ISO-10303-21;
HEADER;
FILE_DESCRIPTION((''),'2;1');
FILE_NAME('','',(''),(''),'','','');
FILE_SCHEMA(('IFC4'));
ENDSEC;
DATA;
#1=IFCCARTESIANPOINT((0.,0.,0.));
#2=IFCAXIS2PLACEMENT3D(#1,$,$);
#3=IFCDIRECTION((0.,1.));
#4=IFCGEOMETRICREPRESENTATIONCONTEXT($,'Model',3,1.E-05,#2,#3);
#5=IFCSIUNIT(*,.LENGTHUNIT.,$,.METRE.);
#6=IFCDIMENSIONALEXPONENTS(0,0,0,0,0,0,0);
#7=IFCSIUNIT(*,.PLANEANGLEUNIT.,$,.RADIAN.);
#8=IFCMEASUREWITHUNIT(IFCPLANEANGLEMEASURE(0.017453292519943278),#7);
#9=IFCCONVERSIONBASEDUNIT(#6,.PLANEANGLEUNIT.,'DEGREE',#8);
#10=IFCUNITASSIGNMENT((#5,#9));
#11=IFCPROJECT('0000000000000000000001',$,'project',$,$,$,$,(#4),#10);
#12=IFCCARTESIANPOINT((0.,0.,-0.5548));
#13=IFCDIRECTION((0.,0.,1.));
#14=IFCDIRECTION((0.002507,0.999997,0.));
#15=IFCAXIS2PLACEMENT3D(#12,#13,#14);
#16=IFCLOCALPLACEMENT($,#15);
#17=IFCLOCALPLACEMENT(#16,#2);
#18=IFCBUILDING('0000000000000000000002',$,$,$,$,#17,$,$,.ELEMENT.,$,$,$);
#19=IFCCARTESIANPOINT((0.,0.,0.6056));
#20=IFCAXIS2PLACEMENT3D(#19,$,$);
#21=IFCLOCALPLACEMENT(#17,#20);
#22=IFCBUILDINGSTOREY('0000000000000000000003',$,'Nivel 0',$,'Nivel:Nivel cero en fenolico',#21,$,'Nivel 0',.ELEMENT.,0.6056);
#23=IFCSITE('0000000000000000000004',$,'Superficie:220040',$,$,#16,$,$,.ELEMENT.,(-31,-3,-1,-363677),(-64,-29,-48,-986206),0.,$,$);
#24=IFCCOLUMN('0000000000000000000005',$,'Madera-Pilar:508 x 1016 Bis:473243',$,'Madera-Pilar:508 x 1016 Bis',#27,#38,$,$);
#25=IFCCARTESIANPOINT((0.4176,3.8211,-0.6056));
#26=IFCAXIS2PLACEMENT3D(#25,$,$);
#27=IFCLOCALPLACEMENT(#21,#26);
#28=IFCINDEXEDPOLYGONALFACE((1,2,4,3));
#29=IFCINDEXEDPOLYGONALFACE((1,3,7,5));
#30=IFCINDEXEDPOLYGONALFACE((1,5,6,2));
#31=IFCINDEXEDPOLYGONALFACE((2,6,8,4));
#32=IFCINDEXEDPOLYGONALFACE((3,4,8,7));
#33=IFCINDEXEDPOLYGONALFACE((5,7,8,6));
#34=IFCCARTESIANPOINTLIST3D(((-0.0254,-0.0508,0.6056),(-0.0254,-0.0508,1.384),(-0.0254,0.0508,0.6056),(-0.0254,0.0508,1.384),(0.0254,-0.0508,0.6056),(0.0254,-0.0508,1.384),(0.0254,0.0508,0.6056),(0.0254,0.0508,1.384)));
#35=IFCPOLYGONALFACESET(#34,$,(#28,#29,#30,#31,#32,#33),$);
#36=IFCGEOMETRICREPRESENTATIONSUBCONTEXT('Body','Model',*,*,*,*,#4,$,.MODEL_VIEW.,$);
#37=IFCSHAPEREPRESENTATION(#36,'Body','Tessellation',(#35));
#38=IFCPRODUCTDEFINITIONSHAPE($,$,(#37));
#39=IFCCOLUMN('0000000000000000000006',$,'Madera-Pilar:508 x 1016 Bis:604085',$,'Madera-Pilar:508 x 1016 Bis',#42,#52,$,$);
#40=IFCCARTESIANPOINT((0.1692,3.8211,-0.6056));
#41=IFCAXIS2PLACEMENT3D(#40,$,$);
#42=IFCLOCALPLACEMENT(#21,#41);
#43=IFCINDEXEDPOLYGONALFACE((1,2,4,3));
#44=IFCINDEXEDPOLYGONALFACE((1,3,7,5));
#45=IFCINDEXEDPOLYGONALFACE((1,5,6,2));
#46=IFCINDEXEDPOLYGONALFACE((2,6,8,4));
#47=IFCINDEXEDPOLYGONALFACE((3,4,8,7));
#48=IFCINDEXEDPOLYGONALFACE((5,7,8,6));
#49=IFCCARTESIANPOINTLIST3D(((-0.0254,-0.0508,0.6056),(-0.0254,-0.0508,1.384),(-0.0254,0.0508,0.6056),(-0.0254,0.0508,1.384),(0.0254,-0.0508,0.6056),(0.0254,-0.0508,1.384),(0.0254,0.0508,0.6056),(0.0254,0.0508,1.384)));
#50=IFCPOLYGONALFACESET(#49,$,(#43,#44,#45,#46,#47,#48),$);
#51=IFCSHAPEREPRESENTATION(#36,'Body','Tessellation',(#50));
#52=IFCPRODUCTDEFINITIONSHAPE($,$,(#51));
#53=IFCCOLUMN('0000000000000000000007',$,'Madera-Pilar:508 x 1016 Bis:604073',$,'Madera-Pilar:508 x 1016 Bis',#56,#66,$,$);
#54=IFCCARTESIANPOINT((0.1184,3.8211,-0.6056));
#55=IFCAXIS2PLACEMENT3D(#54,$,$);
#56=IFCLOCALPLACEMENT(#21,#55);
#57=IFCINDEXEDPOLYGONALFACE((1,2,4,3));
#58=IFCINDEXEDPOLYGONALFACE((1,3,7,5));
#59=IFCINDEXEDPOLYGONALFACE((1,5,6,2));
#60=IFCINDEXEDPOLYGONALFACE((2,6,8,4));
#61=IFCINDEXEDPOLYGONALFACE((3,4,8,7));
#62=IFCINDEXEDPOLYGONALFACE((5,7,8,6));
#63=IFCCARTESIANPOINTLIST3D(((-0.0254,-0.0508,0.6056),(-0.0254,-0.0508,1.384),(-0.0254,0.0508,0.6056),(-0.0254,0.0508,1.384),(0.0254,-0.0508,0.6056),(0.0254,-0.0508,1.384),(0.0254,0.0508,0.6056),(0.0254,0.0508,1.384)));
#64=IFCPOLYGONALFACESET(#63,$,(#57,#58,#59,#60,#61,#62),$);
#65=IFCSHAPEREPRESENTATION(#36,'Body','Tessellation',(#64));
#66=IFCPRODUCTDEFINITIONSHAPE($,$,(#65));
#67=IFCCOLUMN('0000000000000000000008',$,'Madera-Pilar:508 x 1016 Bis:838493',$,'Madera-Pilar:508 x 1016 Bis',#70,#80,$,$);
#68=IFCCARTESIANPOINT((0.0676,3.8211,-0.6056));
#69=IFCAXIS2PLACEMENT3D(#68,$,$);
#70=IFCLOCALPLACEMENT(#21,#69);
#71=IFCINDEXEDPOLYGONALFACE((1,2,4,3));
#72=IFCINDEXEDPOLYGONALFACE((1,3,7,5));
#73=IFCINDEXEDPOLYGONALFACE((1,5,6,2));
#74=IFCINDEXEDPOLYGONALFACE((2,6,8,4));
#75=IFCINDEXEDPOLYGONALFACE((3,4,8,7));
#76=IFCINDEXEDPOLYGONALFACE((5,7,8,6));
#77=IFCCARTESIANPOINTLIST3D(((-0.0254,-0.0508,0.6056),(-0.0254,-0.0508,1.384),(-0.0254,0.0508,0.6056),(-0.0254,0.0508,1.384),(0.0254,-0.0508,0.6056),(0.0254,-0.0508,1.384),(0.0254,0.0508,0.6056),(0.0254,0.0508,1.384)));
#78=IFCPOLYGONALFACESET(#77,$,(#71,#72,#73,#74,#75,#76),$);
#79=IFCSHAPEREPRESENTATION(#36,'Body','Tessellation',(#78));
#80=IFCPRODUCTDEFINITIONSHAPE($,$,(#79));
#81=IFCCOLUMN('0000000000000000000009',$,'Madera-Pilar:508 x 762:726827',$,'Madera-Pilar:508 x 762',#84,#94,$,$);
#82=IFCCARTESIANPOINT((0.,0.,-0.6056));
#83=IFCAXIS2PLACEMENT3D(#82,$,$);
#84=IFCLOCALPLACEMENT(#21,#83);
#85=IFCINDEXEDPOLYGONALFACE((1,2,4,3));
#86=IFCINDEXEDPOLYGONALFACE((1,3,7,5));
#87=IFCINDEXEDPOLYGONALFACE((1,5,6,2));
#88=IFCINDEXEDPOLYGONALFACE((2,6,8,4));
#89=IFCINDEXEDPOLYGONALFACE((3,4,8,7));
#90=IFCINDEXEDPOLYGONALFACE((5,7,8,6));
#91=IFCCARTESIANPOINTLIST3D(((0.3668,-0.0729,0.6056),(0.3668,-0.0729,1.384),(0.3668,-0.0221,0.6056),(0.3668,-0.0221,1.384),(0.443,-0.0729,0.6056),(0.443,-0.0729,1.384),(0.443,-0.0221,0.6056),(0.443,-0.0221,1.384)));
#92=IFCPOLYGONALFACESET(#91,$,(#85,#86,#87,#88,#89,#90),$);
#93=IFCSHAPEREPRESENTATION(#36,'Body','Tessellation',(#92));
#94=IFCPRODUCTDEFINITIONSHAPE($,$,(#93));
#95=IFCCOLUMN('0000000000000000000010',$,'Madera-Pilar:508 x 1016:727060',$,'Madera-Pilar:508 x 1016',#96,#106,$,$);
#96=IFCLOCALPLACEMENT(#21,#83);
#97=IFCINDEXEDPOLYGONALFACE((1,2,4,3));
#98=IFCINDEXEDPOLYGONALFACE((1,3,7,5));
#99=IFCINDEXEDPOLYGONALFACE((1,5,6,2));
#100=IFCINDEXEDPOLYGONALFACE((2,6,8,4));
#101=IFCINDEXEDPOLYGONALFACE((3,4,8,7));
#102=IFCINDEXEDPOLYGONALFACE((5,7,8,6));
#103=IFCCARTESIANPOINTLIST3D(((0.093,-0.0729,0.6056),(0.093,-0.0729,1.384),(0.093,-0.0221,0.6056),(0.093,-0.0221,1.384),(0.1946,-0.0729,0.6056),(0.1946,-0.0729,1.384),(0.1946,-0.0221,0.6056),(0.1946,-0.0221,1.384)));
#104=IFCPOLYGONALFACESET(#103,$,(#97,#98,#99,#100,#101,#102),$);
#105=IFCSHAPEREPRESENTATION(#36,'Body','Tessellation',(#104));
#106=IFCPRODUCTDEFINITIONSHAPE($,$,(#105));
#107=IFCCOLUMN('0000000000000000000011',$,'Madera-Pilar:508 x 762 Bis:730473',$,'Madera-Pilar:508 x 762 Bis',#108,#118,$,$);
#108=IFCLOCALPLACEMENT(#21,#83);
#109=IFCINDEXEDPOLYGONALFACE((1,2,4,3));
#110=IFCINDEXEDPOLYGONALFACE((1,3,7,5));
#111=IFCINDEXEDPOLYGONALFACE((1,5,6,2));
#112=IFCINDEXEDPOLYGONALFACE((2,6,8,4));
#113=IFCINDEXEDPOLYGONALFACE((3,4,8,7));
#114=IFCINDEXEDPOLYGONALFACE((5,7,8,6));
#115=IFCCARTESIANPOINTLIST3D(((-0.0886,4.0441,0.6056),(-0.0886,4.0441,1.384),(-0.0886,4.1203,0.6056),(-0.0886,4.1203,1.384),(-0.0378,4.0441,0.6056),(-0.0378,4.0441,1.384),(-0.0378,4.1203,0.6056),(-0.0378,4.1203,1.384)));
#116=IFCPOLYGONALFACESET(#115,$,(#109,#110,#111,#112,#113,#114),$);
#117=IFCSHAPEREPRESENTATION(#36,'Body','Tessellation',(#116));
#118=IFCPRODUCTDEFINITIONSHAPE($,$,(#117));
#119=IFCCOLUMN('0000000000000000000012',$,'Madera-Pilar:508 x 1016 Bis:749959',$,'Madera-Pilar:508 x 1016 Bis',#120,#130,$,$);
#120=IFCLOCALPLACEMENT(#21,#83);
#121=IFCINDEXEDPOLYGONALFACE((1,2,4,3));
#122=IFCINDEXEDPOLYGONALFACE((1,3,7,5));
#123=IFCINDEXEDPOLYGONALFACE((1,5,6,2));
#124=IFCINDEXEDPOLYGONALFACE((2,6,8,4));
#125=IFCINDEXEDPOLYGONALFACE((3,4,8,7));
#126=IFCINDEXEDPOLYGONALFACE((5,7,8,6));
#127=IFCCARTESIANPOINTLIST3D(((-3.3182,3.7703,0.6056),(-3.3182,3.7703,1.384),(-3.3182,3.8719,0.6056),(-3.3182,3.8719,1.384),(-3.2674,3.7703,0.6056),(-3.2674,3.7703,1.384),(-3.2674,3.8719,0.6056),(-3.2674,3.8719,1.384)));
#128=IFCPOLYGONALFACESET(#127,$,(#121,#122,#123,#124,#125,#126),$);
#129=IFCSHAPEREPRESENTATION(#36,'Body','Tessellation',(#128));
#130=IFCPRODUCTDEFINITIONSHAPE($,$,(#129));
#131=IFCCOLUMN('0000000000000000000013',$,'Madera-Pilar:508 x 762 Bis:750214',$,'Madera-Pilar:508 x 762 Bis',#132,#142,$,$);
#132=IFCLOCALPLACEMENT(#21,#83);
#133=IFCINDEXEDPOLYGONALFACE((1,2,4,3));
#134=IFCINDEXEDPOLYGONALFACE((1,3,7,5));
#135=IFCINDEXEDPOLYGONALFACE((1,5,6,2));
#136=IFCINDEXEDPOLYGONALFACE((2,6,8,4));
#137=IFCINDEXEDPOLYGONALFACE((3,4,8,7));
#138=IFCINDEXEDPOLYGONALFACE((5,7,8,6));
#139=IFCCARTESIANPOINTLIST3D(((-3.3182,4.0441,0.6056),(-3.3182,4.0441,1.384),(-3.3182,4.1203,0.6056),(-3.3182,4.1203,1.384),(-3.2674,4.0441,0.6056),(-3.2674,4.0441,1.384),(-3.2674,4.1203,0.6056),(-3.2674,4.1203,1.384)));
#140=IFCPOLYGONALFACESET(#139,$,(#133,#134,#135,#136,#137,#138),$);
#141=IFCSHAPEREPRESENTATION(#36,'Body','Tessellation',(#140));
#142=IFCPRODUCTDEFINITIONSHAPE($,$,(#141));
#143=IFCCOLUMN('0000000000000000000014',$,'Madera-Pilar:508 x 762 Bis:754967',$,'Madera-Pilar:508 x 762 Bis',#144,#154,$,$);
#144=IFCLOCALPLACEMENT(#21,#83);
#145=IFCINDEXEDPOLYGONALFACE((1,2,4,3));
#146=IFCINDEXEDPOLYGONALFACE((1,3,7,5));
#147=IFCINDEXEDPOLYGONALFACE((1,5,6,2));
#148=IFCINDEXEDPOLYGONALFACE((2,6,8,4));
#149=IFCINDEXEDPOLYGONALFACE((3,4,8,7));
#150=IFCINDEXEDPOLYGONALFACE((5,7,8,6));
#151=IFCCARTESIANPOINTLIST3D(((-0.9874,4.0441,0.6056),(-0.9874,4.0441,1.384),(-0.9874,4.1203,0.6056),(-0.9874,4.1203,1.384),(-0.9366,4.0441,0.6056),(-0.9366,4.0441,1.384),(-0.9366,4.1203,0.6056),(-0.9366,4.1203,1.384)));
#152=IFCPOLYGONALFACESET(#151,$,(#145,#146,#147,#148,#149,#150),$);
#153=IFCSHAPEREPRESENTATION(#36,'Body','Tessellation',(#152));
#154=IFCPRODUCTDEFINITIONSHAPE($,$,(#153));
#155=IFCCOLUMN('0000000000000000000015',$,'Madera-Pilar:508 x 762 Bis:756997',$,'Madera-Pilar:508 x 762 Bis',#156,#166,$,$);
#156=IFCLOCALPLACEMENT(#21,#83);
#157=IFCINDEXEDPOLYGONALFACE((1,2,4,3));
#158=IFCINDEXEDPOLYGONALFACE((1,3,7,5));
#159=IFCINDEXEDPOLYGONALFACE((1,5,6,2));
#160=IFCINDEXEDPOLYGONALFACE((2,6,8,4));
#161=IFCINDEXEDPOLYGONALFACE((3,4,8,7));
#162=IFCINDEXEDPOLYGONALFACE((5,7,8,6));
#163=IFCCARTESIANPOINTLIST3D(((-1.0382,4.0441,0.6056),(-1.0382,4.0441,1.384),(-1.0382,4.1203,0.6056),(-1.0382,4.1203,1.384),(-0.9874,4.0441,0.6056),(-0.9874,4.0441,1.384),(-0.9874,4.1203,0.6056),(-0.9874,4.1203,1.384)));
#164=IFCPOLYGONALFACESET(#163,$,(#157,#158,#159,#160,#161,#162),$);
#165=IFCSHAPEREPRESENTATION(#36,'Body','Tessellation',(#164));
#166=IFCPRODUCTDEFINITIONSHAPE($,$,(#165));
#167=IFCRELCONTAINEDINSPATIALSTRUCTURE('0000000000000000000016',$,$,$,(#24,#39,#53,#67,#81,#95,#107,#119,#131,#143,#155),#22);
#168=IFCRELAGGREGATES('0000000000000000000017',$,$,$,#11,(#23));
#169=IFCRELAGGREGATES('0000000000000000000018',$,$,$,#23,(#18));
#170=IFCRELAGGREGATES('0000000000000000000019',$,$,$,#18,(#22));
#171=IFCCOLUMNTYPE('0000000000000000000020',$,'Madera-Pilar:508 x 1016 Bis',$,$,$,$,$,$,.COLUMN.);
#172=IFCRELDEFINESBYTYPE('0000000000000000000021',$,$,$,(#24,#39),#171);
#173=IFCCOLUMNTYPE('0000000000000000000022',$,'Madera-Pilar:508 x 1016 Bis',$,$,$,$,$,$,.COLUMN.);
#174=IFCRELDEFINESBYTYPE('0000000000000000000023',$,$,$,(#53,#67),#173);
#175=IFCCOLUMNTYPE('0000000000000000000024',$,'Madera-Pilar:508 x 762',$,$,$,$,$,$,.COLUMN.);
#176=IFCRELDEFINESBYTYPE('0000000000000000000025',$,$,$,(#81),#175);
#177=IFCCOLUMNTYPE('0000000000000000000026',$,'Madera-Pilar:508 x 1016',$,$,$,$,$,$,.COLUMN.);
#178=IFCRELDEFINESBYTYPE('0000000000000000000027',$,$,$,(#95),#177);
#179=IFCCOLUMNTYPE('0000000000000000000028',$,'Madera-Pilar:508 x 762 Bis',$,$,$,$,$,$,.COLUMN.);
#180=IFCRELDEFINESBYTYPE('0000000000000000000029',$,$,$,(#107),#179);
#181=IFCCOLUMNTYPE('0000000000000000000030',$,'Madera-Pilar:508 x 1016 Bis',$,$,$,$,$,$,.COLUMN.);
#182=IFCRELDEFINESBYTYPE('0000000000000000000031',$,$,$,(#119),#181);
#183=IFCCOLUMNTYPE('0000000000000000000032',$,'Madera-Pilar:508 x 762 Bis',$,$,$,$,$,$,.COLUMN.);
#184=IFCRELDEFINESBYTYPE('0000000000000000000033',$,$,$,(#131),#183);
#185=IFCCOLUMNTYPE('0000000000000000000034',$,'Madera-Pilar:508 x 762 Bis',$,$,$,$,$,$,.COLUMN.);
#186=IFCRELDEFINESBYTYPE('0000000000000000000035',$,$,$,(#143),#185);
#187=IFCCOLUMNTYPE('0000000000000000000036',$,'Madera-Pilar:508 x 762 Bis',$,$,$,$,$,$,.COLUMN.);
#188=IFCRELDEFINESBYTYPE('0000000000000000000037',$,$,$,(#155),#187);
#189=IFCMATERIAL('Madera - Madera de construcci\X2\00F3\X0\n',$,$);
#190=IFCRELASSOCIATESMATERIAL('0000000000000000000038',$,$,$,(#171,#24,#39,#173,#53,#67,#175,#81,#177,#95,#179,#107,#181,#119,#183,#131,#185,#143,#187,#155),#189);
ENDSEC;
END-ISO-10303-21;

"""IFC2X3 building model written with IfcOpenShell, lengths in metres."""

from ifc_helpers import new_model, entity, si_unit, converted_unit, direction, frame, frame_2d, origin, origin_2d_with_axis, place, context, subcontext, project, spatial, rectangle, extrude, source, transform, mapped, material, type_object, type_shapes, element, save


model = new_model("IFC2X3")

# Units and contexts
model_context = context("Model", 3, precision=1e-05, world=origin(), true_north=direction((0.0, 1.0)))
body_context = subcontext(model_context, "Body", "Model", "MODEL_VIEW")
ifc_project = project(units=[si_unit("LENGTHUNIT", "METRE"), converted_unit("PLANEANGLEUNIT", "DEGREE", entity("IfcPlaneAngleMeasure", 0.017453292519943278), si_unit("PLANEANGLEUNIT", "RADIAN"), dimensions=[0, 0, 0, 0, 0, 0, 0])], contexts=[model_context])

# Site, building, storey
site_placement = place(None, frame((0.0, 0.0, -0.5548), z_axis=(0.0, 0.0, 1.0), x_axis=(0.002507, 0.999997, 0.0)))
site = spatial("IfcSite", under=ifc_project, at=site_placement, Name="Superficie:220040", CompositionType="ELEMENT", RefLatitude=(-31, -3, -1, -363677), RefLongitude=(-64, -29, -48, -986206), RefElevation=0.0)
building_placement = place(site_placement, origin())
building = spatial("IfcBuilding", under=site, at=building_placement, CompositionType="ELEMENT")
storey_placement = place(building_placement, frame((0.0, 0.0, 0.6056)))
storey = spatial("IfcBuildingStorey", under=building, at=storey_placement, Name="Nivel 0", ObjectType="Nivel:Nivel cero en fenolico", LongName="Nivel 0", CompositionType="ELEMENT", Elevation=0.6056)

# Columns
ifc_material = material(Name="Madera - Madera de construcción")
column_type_1 = type_object("IfcColumnType", Name="Madera-Pilar:508 x 1016 Bis", PredefinedType="COLUMN", material=ifc_material)
shared_shape_1 = source(origin(), body_context, "Body", "SweptSolid", [
    extrude(rectangle(XDim=0.0508, YDim=0.1016, at=origin_2d_with_axis()), frame((0.0, 0.0, 0.6056), z_axis=(0.0, 0.0, 1.0), x_axis=(-1.0, 0.0, 0.0)), (0.0, 0.0, 1.0), 0.7784),
])
type_shapes(column_type_1, [shared_shape_1])
for number, where, name in (
    (1, (0.4176, 3.8211, -0.6056), "Madera-Pilar:508 x 1016 Bis:473243"),
    (2, (0.1692, 3.8211, -0.6056), "Madera-Pilar:508 x 1016 Bis:604085"),
):
    element("IfcColumn", number, at=place(storey_placement, frame(where)), inside=storey, type_object=column_type_1, material=ifc_material, Name=name, ObjectType="Madera-Pilar:508 x 1016 Bis", context=body_context, shape_type="MappedRepresentation", body=[
        mapped(shared_shape_1, transform((0.0, 0.0, 0.0), scale=1.0)),
    ])
column_type_2 = type_object("IfcColumnType", Name="Madera-Pilar:508 x 1016 Bis", PredefinedType="COLUMN", material=ifc_material)
shared_shape_2 = source(origin(), body_context, "Body", "SweptSolid", [
    extrude(rectangle(XDim=0.0508, YDim=0.1016, at=origin_2d_with_axis()), frame((0.0, 0.0, 0.6056), z_axis=(0.0, 0.0, 1.0), x_axis=(-1.0, 0.0, 0.0)), (0.0, 0.0, 1.0), 0.7784),
])
type_shapes(column_type_2, [shared_shape_2])
for number, where, name in (
    (3, (0.1184, 3.8211, -0.6056), "Madera-Pilar:508 x 1016 Bis:604073"),
    (4, (0.0676, 3.8211, -0.6056), "Madera-Pilar:508 x 1016 Bis:838493"),
):
    element("IfcColumn", number, at=place(storey_placement, frame(where)), inside=storey, type_object=column_type_2, material=ifc_material, Name=name, ObjectType="Madera-Pilar:508 x 1016 Bis", context=body_context, shape_type="MappedRepresentation", body=[
        mapped(shared_shape_2, transform((0.0, 0.0, 0.0), scale=1.0)),
    ])
column_type_3 = type_object("IfcColumnType", Name="Madera-Pilar:508 x 762", PredefinedType="COLUMN", material=ifc_material)
shared_shape_3 = source(origin(), body_context, "Body", "SweptSolid", [
    extrude(rectangle(XDim=0.0762, YDim=0.0508, at=frame_2d((0.0, 0.0), x_axis=(1.0, 0.0))), frame((0.4049, -0.0475, 0.6056), z_axis=(0.0, 0.0, 1.0), x_axis=(-1.0, 0.0, 0.0)), (0.0, 0.0, 1.0), 0.7784),
])
type_shapes(column_type_3, [shared_shape_3])
column_1_placement = place(storey_placement, frame((0.0, 0.0, -0.6056)))
element("IfcColumn", 5, at=column_1_placement, inside=storey, type_object=column_type_3, material=ifc_material, Name="Madera-Pilar:508 x 762:726827", ObjectType="Madera-Pilar:508 x 762", context=body_context, shape_type="MappedRepresentation", body=[
    mapped(shared_shape_3, transform((0.0, 0.0, 0.0), scale=1.0)),
])
column_type_4 = type_object("IfcColumnType", Name="Madera-Pilar:508 x 1016", PredefinedType="COLUMN", material=ifc_material)
shared_shape_4 = source(origin(), body_context, "Body", "SweptSolid", [
    extrude(rectangle(XDim=0.1016, YDim=0.0508, at=frame_2d((0.0, 0.0), x_axis=(1.0, 0.0))), frame((0.1438, -0.0475, 0.6056), z_axis=(0.0, 0.0, 1.0), x_axis=(-1.0, 0.0, 0.0)), (0.0, 0.0, 1.0), 0.7784),
])
type_shapes(column_type_4, [shared_shape_4])
column_2_placement = place(storey_placement, frame((0.0, 0.0, -0.6056)))
element("IfcColumn", 6, at=column_2_placement, inside=storey, type_object=column_type_4, material=ifc_material, Name="Madera-Pilar:508 x 1016:727060", ObjectType="Madera-Pilar:508 x 1016", context=body_context, shape_type="MappedRepresentation", body=[
    mapped(shared_shape_4, transform((0.0, 0.0, 0.0), scale=1.0)),
])
column_type_5 = type_object("IfcColumnType", Name="Madera-Pilar:508 x 762 Bis", PredefinedType="COLUMN", material=ifc_material)
shared_shape_5 = source(origin(), body_context, "Body", "SweptSolid", [
    extrude(rectangle(XDim=0.0508, YDim=0.0762, at=origin_2d_with_axis()), frame((-0.0632, 4.0822, 0.6056), z_axis=(0.0, 0.0, 1.0), x_axis=(-1.0, 0.0, 0.0)), (0.0, 0.0, 1.0), 0.7784),
])
type_shapes(column_type_5, [shared_shape_5])
column_3_placement = place(storey_placement, frame((0.0, 0.0, -0.6056)))
element("IfcColumn", 7, at=column_3_placement, inside=storey, type_object=column_type_5, material=ifc_material, Name="Madera-Pilar:508 x 762 Bis:730473", ObjectType="Madera-Pilar:508 x 762 Bis", context=body_context, shape_type="MappedRepresentation", body=[
    mapped(shared_shape_5, transform((0.0, 0.0, 0.0), scale=1.0)),
])
column_type_6 = type_object("IfcColumnType", Name="Madera-Pilar:508 x 1016 Bis", PredefinedType="COLUMN", material=ifc_material)
shared_shape_6 = source(origin(), body_context, "Body", "SweptSolid", [
    extrude(rectangle(XDim=0.0508, YDim=0.1016, at=frame_2d((0.0, 0.0), x_axis=(1.0, 0.0))), frame((-3.2928, 3.8211, 0.6056), z_axis=(0.0, 0.0, 1.0), x_axis=(-1.0, 0.0, 0.0)), (0.0, 0.0, 1.0), 0.7784),
])
type_shapes(column_type_6, [shared_shape_6])
column_4_placement = place(storey_placement, frame((0.0, 0.0, -0.6056)))
element("IfcColumn", 8, at=column_4_placement, inside=storey, type_object=column_type_6, material=ifc_material, Name="Madera-Pilar:508 x 1016 Bis:749959", ObjectType="Madera-Pilar:508 x 1016 Bis", context=body_context, shape_type="MappedRepresentation", body=[
    mapped(shared_shape_6, transform((0.0, 0.0, 0.0), scale=1.0)),
])
column_type_7 = type_object("IfcColumnType", Name="Madera-Pilar:508 x 762 Bis", PredefinedType="COLUMN", material=ifc_material)
shared_shape_7 = source(origin(), body_context, "Body", "SweptSolid", [
    extrude(rectangle(XDim=0.0508, YDim=0.0762, at=frame_2d((0.0, 0.0), x_axis=(1.0, 0.0))), frame((-3.2928, 4.0822, 0.6056), z_axis=(0.0, 0.0, 1.0), x_axis=(-1.0, 0.0, 0.0)), (0.0, 0.0, 1.0), 0.7784),
])
type_shapes(column_type_7, [shared_shape_7])
column_5_placement = place(storey_placement, frame((0.0, 0.0, -0.6056)))
element("IfcColumn", 9, at=column_5_placement, inside=storey, type_object=column_type_7, material=ifc_material, Name="Madera-Pilar:508 x 762 Bis:750214", ObjectType="Madera-Pilar:508 x 762 Bis", context=body_context, shape_type="MappedRepresentation", body=[
    mapped(shared_shape_7, transform((0.0, 0.0, 0.0), scale=1.0)),
])
column_type_8 = type_object("IfcColumnType", Name="Madera-Pilar:508 x 762 Bis", PredefinedType="COLUMN", material=ifc_material)
shared_shape_8 = source(origin(), body_context, "Body", "SweptSolid", [
    extrude(rectangle(XDim=0.0508, YDim=0.0762, at=frame_2d((0.0, 0.0), x_axis=(1.0, 0.0))), frame((-0.962, 4.0822, 0.6056), z_axis=(0.0, 0.0, 1.0), x_axis=(-1.0, 0.0, 0.0)), (0.0, 0.0, 1.0), 0.7784),
])
type_shapes(column_type_8, [shared_shape_8])
column_6_placement = place(storey_placement, frame((0.0, 0.0, -0.6056)))
element("IfcColumn", 10, at=column_6_placement, inside=storey, type_object=column_type_8, material=ifc_material, Name="Madera-Pilar:508 x 762 Bis:754967", ObjectType="Madera-Pilar:508 x 762 Bis", context=body_context, shape_type="MappedRepresentation", body=[
    mapped(shared_shape_8, transform((0.0, 0.0, 0.0), scale=1.0)),
])
column_type_9 = type_object("IfcColumnType", Name="Madera-Pilar:508 x 762 Bis", PredefinedType="COLUMN", material=ifc_material)
shared_shape_9 = source(origin(), body_context, "Body", "SweptSolid", [
    extrude(rectangle(XDim=0.0508, YDim=0.0762, at=frame_2d((0.0, 0.0), x_axis=(1.0, 0.0))), frame((-1.0128, 4.0822, 0.6056), z_axis=(0.0, 0.0, 1.0), x_axis=(-1.0, 0.0, 0.0)), (0.0, 0.0, 1.0), 0.7784),
])
type_shapes(column_type_9, [shared_shape_9])
column_7_placement = place(storey_placement, frame((0.0, 0.0, -0.6056)))
element("IfcColumn", 11, at=column_7_placement, inside=storey, type_object=column_type_9, material=ifc_material, Name="Madera-Pilar:508 x 762 Bis:756997", ObjectType="Madera-Pilar:508 x 762 Bis", context=body_context, shape_type="MappedRepresentation", body=[
    mapped(shared_shape_9, transform((0.0, 0.0, 0.0), scale=1.0)),
])

save(model, "model.ifc")
